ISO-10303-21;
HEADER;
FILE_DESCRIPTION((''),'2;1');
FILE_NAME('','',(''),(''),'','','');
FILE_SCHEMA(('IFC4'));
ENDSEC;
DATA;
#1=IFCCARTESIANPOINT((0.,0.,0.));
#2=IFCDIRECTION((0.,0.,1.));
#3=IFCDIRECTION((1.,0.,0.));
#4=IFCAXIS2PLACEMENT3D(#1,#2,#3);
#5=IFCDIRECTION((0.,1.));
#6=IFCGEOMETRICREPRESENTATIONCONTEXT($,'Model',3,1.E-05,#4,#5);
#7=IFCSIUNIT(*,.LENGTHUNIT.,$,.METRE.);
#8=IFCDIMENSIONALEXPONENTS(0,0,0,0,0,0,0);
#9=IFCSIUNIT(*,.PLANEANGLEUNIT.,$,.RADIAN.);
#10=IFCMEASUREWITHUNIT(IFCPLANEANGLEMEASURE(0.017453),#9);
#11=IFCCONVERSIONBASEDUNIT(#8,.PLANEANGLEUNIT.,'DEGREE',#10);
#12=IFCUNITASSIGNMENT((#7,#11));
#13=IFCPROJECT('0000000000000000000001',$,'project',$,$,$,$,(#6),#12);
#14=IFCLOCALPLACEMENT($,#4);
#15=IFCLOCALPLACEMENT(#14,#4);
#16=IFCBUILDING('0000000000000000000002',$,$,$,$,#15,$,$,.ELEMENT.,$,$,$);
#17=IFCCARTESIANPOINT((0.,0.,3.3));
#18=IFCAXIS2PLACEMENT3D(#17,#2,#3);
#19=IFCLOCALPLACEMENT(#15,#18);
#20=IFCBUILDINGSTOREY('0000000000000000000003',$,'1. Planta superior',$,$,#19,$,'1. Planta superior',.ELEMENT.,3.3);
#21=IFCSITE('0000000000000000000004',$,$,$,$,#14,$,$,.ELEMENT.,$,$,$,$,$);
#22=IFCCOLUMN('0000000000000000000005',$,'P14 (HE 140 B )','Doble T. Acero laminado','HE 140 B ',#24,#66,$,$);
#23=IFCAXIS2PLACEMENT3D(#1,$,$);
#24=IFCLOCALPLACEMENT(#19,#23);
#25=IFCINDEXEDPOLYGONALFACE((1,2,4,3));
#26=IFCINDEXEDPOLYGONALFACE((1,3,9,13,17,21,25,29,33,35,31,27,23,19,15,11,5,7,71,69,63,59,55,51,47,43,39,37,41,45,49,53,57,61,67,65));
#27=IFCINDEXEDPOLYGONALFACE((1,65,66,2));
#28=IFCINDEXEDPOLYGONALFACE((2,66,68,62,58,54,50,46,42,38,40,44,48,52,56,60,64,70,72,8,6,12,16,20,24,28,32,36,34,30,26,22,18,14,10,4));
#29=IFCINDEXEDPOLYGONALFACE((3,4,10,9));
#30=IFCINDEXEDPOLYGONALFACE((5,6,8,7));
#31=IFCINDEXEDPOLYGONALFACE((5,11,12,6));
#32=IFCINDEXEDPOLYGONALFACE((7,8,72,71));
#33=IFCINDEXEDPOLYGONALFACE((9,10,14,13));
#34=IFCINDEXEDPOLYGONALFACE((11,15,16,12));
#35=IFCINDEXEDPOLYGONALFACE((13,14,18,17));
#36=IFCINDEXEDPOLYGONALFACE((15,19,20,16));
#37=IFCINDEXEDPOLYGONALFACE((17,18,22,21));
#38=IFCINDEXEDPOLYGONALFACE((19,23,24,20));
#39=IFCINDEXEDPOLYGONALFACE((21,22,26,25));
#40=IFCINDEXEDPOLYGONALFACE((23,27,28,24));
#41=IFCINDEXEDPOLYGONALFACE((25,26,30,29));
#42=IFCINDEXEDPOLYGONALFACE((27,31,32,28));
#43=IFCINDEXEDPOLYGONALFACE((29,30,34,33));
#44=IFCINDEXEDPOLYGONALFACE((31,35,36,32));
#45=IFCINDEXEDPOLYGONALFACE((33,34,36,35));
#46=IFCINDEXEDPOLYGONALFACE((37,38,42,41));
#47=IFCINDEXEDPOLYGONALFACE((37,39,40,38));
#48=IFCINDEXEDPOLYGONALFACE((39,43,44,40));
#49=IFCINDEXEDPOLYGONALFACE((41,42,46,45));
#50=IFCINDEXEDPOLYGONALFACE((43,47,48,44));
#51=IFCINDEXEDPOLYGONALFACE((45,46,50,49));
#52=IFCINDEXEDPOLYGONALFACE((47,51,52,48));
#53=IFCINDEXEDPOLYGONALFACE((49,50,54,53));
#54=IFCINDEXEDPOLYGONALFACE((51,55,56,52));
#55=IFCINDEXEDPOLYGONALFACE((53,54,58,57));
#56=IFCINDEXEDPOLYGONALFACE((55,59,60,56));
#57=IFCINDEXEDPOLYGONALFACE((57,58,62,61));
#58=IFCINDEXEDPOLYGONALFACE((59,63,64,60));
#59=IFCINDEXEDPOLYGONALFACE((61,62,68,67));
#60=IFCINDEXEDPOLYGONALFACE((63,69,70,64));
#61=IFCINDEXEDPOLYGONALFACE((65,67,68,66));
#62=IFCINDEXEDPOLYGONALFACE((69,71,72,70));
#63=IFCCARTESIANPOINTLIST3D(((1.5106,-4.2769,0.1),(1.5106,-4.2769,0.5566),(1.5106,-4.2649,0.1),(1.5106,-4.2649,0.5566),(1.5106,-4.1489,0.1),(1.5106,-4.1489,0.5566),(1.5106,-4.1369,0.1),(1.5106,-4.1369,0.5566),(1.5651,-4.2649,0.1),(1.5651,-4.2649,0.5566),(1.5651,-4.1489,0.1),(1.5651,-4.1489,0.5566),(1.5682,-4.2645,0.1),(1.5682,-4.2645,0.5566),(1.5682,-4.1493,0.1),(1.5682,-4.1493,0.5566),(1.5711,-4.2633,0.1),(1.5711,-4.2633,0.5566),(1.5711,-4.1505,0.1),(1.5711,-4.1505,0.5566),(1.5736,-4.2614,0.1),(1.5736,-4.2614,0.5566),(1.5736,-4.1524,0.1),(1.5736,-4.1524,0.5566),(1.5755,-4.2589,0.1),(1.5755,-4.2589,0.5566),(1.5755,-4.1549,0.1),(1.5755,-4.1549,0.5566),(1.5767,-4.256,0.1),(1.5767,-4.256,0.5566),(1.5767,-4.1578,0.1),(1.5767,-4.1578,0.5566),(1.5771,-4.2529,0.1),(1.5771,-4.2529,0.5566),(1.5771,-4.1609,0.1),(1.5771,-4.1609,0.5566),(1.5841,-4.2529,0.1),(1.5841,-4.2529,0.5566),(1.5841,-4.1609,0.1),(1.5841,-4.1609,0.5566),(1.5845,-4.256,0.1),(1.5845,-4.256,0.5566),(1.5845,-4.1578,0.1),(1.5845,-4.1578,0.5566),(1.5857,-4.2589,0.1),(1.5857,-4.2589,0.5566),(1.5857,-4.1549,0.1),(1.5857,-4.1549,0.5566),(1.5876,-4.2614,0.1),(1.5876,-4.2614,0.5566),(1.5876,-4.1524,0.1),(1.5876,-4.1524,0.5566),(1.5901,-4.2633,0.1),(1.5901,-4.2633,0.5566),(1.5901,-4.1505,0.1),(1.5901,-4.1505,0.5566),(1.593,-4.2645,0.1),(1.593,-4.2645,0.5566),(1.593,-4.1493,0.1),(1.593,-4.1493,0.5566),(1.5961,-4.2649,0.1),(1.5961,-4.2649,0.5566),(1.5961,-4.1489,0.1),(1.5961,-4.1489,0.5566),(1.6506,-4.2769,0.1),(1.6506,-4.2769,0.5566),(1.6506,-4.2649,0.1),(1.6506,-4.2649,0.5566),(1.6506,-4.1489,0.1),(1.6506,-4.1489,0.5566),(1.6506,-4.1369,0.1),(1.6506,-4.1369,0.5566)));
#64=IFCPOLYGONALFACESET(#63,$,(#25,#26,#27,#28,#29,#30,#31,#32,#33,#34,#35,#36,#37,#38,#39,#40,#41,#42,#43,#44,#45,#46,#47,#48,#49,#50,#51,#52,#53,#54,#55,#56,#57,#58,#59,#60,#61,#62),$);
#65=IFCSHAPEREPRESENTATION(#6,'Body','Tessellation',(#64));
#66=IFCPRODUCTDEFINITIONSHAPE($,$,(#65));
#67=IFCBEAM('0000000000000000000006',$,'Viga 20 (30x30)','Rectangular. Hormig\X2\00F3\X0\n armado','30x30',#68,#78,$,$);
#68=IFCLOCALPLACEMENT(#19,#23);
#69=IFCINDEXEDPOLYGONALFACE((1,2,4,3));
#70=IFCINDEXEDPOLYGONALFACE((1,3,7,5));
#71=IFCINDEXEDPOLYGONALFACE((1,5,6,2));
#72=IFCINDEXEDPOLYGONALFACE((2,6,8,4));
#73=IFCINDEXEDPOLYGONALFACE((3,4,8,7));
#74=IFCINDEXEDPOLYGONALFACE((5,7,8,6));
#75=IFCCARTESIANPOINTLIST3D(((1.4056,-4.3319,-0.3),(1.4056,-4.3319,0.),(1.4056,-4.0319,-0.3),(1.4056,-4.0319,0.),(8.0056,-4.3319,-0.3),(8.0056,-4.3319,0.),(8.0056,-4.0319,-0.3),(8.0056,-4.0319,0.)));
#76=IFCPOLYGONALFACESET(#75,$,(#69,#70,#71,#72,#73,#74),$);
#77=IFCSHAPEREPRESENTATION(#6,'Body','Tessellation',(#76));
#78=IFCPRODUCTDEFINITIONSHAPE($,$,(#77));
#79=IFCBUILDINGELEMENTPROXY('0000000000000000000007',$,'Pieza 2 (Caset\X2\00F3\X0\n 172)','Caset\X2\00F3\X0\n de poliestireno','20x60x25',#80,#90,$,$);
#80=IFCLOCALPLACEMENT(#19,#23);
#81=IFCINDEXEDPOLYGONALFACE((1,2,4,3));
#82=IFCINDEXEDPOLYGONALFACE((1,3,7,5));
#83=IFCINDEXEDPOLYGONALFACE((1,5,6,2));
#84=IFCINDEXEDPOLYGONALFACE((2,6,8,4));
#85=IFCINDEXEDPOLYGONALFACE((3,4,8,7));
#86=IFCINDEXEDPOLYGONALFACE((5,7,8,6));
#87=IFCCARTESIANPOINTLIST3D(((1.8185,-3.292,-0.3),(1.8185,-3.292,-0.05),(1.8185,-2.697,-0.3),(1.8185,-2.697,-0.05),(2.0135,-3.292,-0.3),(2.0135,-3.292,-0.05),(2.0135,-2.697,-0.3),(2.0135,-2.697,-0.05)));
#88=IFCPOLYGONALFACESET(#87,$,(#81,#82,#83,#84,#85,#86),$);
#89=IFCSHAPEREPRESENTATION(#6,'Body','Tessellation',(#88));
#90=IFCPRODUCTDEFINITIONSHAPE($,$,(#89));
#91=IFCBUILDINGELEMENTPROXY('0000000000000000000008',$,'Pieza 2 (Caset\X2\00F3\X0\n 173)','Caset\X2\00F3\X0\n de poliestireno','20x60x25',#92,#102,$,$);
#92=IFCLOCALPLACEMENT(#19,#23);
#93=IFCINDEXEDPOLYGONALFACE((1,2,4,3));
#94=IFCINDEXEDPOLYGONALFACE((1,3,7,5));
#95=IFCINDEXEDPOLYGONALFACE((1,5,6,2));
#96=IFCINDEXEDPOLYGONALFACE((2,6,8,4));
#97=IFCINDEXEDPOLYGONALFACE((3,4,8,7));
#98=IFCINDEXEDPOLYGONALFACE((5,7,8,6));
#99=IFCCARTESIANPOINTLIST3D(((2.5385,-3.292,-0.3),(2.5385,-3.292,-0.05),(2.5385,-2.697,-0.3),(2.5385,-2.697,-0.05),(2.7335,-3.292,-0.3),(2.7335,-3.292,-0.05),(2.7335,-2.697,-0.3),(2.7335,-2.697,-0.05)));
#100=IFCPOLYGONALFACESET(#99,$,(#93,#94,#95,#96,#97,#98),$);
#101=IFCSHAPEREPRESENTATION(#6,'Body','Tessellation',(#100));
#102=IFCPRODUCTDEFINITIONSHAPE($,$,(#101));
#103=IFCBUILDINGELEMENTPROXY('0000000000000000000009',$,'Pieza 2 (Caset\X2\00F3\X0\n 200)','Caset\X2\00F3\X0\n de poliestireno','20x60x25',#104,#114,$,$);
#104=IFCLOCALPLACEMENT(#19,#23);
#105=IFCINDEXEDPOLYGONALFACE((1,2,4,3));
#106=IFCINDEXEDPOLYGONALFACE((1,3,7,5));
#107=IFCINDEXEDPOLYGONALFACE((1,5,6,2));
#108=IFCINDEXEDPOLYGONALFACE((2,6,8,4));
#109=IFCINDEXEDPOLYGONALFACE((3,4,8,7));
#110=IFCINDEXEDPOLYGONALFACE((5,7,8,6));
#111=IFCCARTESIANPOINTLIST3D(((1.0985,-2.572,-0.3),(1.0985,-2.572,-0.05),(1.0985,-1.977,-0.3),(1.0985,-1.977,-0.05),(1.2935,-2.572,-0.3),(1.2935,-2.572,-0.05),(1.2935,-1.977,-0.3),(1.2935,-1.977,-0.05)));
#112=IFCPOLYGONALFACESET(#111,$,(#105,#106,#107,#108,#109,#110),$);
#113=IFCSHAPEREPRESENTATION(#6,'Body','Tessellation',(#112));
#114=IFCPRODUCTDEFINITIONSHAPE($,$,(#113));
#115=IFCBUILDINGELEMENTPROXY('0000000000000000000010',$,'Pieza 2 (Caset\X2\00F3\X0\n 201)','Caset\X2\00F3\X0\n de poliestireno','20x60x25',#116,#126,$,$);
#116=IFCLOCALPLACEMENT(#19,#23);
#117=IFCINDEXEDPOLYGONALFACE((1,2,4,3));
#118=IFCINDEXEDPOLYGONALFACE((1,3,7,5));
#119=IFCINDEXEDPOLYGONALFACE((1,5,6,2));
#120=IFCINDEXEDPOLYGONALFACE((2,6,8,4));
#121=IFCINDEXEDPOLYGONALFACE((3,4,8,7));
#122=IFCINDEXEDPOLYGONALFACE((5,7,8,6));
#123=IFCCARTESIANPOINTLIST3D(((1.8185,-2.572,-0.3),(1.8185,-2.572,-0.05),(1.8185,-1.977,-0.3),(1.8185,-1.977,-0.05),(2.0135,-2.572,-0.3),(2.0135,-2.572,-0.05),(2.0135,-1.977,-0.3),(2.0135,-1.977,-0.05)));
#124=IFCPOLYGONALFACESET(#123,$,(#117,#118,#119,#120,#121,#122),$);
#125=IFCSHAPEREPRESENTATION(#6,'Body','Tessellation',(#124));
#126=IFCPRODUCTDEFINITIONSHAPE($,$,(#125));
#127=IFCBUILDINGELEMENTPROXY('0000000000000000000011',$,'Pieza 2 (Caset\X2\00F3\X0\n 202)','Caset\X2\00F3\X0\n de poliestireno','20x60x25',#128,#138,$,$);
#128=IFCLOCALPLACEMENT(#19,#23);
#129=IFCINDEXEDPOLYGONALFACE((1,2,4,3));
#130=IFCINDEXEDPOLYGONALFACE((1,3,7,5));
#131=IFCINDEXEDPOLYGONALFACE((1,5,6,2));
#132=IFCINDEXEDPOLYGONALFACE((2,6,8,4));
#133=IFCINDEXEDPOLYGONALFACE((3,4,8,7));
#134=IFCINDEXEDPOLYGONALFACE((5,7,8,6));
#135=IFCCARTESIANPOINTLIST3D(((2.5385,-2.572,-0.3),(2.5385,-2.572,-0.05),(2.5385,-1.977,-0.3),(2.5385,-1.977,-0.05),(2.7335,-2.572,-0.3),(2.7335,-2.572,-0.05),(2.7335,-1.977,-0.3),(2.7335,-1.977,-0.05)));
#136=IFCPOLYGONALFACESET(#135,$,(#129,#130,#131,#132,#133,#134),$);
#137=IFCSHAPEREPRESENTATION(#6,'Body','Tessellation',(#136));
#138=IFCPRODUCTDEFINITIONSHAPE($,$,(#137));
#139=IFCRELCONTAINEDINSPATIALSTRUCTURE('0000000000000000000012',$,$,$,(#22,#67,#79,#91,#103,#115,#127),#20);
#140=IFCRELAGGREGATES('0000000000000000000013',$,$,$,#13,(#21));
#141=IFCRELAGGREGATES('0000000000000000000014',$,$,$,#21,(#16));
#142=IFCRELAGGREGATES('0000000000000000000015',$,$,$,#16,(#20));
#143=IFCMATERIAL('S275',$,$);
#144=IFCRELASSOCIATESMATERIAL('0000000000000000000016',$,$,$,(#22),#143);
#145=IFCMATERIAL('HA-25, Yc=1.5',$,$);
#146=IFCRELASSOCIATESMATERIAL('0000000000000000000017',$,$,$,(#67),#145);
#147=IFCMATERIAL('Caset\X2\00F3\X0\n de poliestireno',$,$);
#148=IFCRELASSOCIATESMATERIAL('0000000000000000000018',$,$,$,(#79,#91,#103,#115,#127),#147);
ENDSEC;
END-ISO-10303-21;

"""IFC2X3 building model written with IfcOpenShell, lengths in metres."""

from ifc_helpers import new_model, entity, si_unit, converted_unit, direction, frame, frame_2d, origin_with_axes, origin_2d_with_axis, place, context, project, spatial, rectangle, i_section, extrude, source, transform, mapped, material, element, save


model = new_model("IFC2X3")

# Units and contexts
model_context = context("Model", 3, precision=1e-05, world=origin_with_axes(), true_north=direction((0.0, 1.0)))
ifc_project = project(units=[si_unit("LENGTHUNIT", "METRE"), converted_unit("PLANEANGLEUNIT", "DEGREE", entity("IfcPlaneAngleMeasure", 0.017453), si_unit("PLANEANGLEUNIT", "RADIAN"), dimensions=[0, 0, 0, 0, 0, 0, 0])], contexts=[model_context])

# Site, building, storey
site_placement = place(None, origin_with_axes())
site = spatial("IfcSite", under=ifc_project, at=site_placement, CompositionType="ELEMENT")
building_placement = place(site_placement, origin_with_axes())
building = spatial("IfcBuilding", under=site, at=building_placement, CompositionType="ELEMENT")
storey_placement = place(building_placement, frame((0.0, 0.0, 3.3), z_axis=(0.0, 0.0, 1.0), x_axis=(1.0, 0.0, 0.0)))
storey = spatial("IfcBuildingStorey", under=building, at=storey_placement, Name="1. Planta superior", LongName="1. Planta superior", CompositionType="ELEMENT", Elevation=3.3)

# Column
ifc_material_1 = material(Name="S275")
column_placement = place(storey_placement, frame((1.5806, -4.2069, 0.1), z_axis=(0.0, 0.0, 1.0), x_axis=(1.0, 0.0, 0.0)))
element("IfcColumn", 1, at=column_placement, inside=storey, material=ifc_material_1, Name="P14 (HE 140 B )", Description="Doble T. Acero laminado", ObjectType="HE 140 B ", context=model_context, shape_type="SweptSolid", body=[
    extrude(i_section(OverallWidth=0.14, OverallDepth=0.14, WebThickness=0.007, FlangeThickness=0.012, FilletRadius=0.012, at=origin_2d_with_axis()), origin_with_axes(), (0.0, 0.0, 1.0), 0.4566),
])

# Beam
ifc_material_2 = material(Name="HA-25, Yc=1.5")
beam_placement = place(storey_placement, frame((1.4056, -4.1819, 0.0), z_axis=(1.0, 0.0, 0.0), x_axis=(0.0, 1.0, 0.0)))
element("IfcBeam", 2, at=beam_placement, inside=storey, material=ifc_material_2, Name="Viga 20 (30x30)", Description="Rectangular. Hormigón armado", ObjectType="30x30", context=model_context, shape_type="SweptSolid", body=[
    extrude(rectangle(XDim=0.3, YDim=0.3, at=frame_2d((0.0, -0.15), x_axis=(1.0, 0.0))), origin_with_axes(), (0.0, 0.0, 1.0), 6.6),
])

# Building element proxies
ifc_material_3 = material(Name="Casetón de poliestireno")
shared_shape = source(origin_with_axes(), model_context, "Body", "SweptSolid", [
    extrude(rectangle(XDim=0.195, YDim=0.25, at=origin_2d_with_axis()), origin_with_axes(), (0.0, 0.0, 1.0), 0.595),
])
placement_1 = place(storey_placement, frame((1.916, -3.292, -0.175), z_axis=(0.0, 1.0, 0.0), x_axis=(-1.0, 0.0, 0.0)))
for number, where, z_axis, x_axis, name in (
    (3, (0.0, 0.0, 0.0), (0.0, 0.0, 1.0), (1.0, 0.0, 0.0), "Pieza 2 (Casetón 172)"),
):
    element("IfcBuildingElementProxy", number, at=place(placement_1, frame(where, z_axis=z_axis, x_axis=x_axis)), inside=storey, material=ifc_material_3, Name=name, Description="Casetón de poliestireno", ObjectType="20x60x25", context=model_context, shape_type="MappedRepresentation", body=[
        mapped(shared_shape, transform((0.0, 0.0, 0.0), x_axis=(1.0, 0.0, 0.0), y_axis=(0.0, 1.0, 0.0), z_axis=(0.0, 0.0, 1.0))),
    ])
placement_2 = place(storey_placement, frame((2.636, -3.292, -0.175), z_axis=(0.0, 1.0, 0.0), x_axis=(-1.0, 0.0, 0.0)))
for number, where, z_axis, x_axis, name in (
    (4, (0.0, 0.0, 0.0), (0.0, 0.0, 1.0), (1.0, 0.0, 0.0), "Pieza 2 (Casetón 173)"),
):
    element("IfcBuildingElementProxy", number, at=place(placement_2, frame(where, z_axis=z_axis, x_axis=x_axis)), inside=storey, material=ifc_material_3, Name=name, Description="Casetón de poliestireno", ObjectType="20x60x25", context=model_context, shape_type="MappedRepresentation", body=[
        mapped(shared_shape, transform((0.0, 0.0, 0.0), x_axis=(1.0, 0.0, 0.0), y_axis=(0.0, 1.0, 0.0), z_axis=(0.0, 0.0, 1.0))),
    ])
placement_3 = place(storey_placement, frame((1.196, -2.572, -0.175), z_axis=(0.0, 1.0, 0.0), x_axis=(-1.0, 0.0, 0.0)))
for number, where, z_axis, x_axis, name in (
    (5, (0.0, 0.0, 0.0), (0.0, 0.0, 1.0), (1.0, 0.0, 0.0), "Pieza 2 (Casetón 200)"),
):
    element("IfcBuildingElementProxy", number, at=place(placement_3, frame(where, z_axis=z_axis, x_axis=x_axis)), inside=storey, material=ifc_material_3, Name=name, Description="Casetón de poliestireno", ObjectType="20x60x25", context=model_context, shape_type="MappedRepresentation", body=[
        mapped(shared_shape, transform((0.0, 0.0, 0.0), x_axis=(1.0, 0.0, 0.0), y_axis=(0.0, 1.0, 0.0), z_axis=(0.0, 0.0, 1.0))),
    ])
placement_4 = place(storey_placement, frame((1.916, -2.572, -0.175), z_axis=(0.0, 1.0, 0.0), x_axis=(-1.0, 0.0, 0.0)))
for number, where, z_axis, x_axis, name in (
    (6, (0.0, 0.0, 0.0), (0.0, 0.0, 1.0), (1.0, 0.0, 0.0), "Pieza 2 (Casetón 201)"),
):
    element("IfcBuildingElementProxy", number, at=place(placement_4, frame(where, z_axis=z_axis, x_axis=x_axis)), inside=storey, material=ifc_material_3, Name=name, Description="Casetón de poliestireno", ObjectType="20x60x25", context=model_context, shape_type="MappedRepresentation", body=[
        mapped(shared_shape, transform((0.0, 0.0, 0.0), x_axis=(1.0, 0.0, 0.0), y_axis=(0.0, 1.0, 0.0), z_axis=(0.0, 0.0, 1.0))),
    ])
placement_5 = place(storey_placement, frame((2.636, -2.572, -0.175), z_axis=(0.0, 1.0, 0.0), x_axis=(-1.0, 0.0, 0.0)))
for number, where, z_axis, x_axis, name in (
    (7, (0.0, 0.0, 0.0), (0.0, 0.0, 1.0), (1.0, 0.0, 0.0), "Pieza 2 (Casetón 202)"),
):
    element("IfcBuildingElementProxy", number, at=place(placement_5, frame(where, z_axis=z_axis, x_axis=x_axis)), inside=storey, material=ifc_material_3, Name=name, Description="Casetón de poliestireno", ObjectType="20x60x25", context=model_context, shape_type="MappedRepresentation", body=[
        mapped(shared_shape, transform((0.0, 0.0, 0.0), x_axis=(1.0, 0.0, 0.0), y_axis=(0.0, 1.0, 0.0), z_axis=(0.0, 0.0, 1.0))),
    ])

save(model, "model.ifc")
